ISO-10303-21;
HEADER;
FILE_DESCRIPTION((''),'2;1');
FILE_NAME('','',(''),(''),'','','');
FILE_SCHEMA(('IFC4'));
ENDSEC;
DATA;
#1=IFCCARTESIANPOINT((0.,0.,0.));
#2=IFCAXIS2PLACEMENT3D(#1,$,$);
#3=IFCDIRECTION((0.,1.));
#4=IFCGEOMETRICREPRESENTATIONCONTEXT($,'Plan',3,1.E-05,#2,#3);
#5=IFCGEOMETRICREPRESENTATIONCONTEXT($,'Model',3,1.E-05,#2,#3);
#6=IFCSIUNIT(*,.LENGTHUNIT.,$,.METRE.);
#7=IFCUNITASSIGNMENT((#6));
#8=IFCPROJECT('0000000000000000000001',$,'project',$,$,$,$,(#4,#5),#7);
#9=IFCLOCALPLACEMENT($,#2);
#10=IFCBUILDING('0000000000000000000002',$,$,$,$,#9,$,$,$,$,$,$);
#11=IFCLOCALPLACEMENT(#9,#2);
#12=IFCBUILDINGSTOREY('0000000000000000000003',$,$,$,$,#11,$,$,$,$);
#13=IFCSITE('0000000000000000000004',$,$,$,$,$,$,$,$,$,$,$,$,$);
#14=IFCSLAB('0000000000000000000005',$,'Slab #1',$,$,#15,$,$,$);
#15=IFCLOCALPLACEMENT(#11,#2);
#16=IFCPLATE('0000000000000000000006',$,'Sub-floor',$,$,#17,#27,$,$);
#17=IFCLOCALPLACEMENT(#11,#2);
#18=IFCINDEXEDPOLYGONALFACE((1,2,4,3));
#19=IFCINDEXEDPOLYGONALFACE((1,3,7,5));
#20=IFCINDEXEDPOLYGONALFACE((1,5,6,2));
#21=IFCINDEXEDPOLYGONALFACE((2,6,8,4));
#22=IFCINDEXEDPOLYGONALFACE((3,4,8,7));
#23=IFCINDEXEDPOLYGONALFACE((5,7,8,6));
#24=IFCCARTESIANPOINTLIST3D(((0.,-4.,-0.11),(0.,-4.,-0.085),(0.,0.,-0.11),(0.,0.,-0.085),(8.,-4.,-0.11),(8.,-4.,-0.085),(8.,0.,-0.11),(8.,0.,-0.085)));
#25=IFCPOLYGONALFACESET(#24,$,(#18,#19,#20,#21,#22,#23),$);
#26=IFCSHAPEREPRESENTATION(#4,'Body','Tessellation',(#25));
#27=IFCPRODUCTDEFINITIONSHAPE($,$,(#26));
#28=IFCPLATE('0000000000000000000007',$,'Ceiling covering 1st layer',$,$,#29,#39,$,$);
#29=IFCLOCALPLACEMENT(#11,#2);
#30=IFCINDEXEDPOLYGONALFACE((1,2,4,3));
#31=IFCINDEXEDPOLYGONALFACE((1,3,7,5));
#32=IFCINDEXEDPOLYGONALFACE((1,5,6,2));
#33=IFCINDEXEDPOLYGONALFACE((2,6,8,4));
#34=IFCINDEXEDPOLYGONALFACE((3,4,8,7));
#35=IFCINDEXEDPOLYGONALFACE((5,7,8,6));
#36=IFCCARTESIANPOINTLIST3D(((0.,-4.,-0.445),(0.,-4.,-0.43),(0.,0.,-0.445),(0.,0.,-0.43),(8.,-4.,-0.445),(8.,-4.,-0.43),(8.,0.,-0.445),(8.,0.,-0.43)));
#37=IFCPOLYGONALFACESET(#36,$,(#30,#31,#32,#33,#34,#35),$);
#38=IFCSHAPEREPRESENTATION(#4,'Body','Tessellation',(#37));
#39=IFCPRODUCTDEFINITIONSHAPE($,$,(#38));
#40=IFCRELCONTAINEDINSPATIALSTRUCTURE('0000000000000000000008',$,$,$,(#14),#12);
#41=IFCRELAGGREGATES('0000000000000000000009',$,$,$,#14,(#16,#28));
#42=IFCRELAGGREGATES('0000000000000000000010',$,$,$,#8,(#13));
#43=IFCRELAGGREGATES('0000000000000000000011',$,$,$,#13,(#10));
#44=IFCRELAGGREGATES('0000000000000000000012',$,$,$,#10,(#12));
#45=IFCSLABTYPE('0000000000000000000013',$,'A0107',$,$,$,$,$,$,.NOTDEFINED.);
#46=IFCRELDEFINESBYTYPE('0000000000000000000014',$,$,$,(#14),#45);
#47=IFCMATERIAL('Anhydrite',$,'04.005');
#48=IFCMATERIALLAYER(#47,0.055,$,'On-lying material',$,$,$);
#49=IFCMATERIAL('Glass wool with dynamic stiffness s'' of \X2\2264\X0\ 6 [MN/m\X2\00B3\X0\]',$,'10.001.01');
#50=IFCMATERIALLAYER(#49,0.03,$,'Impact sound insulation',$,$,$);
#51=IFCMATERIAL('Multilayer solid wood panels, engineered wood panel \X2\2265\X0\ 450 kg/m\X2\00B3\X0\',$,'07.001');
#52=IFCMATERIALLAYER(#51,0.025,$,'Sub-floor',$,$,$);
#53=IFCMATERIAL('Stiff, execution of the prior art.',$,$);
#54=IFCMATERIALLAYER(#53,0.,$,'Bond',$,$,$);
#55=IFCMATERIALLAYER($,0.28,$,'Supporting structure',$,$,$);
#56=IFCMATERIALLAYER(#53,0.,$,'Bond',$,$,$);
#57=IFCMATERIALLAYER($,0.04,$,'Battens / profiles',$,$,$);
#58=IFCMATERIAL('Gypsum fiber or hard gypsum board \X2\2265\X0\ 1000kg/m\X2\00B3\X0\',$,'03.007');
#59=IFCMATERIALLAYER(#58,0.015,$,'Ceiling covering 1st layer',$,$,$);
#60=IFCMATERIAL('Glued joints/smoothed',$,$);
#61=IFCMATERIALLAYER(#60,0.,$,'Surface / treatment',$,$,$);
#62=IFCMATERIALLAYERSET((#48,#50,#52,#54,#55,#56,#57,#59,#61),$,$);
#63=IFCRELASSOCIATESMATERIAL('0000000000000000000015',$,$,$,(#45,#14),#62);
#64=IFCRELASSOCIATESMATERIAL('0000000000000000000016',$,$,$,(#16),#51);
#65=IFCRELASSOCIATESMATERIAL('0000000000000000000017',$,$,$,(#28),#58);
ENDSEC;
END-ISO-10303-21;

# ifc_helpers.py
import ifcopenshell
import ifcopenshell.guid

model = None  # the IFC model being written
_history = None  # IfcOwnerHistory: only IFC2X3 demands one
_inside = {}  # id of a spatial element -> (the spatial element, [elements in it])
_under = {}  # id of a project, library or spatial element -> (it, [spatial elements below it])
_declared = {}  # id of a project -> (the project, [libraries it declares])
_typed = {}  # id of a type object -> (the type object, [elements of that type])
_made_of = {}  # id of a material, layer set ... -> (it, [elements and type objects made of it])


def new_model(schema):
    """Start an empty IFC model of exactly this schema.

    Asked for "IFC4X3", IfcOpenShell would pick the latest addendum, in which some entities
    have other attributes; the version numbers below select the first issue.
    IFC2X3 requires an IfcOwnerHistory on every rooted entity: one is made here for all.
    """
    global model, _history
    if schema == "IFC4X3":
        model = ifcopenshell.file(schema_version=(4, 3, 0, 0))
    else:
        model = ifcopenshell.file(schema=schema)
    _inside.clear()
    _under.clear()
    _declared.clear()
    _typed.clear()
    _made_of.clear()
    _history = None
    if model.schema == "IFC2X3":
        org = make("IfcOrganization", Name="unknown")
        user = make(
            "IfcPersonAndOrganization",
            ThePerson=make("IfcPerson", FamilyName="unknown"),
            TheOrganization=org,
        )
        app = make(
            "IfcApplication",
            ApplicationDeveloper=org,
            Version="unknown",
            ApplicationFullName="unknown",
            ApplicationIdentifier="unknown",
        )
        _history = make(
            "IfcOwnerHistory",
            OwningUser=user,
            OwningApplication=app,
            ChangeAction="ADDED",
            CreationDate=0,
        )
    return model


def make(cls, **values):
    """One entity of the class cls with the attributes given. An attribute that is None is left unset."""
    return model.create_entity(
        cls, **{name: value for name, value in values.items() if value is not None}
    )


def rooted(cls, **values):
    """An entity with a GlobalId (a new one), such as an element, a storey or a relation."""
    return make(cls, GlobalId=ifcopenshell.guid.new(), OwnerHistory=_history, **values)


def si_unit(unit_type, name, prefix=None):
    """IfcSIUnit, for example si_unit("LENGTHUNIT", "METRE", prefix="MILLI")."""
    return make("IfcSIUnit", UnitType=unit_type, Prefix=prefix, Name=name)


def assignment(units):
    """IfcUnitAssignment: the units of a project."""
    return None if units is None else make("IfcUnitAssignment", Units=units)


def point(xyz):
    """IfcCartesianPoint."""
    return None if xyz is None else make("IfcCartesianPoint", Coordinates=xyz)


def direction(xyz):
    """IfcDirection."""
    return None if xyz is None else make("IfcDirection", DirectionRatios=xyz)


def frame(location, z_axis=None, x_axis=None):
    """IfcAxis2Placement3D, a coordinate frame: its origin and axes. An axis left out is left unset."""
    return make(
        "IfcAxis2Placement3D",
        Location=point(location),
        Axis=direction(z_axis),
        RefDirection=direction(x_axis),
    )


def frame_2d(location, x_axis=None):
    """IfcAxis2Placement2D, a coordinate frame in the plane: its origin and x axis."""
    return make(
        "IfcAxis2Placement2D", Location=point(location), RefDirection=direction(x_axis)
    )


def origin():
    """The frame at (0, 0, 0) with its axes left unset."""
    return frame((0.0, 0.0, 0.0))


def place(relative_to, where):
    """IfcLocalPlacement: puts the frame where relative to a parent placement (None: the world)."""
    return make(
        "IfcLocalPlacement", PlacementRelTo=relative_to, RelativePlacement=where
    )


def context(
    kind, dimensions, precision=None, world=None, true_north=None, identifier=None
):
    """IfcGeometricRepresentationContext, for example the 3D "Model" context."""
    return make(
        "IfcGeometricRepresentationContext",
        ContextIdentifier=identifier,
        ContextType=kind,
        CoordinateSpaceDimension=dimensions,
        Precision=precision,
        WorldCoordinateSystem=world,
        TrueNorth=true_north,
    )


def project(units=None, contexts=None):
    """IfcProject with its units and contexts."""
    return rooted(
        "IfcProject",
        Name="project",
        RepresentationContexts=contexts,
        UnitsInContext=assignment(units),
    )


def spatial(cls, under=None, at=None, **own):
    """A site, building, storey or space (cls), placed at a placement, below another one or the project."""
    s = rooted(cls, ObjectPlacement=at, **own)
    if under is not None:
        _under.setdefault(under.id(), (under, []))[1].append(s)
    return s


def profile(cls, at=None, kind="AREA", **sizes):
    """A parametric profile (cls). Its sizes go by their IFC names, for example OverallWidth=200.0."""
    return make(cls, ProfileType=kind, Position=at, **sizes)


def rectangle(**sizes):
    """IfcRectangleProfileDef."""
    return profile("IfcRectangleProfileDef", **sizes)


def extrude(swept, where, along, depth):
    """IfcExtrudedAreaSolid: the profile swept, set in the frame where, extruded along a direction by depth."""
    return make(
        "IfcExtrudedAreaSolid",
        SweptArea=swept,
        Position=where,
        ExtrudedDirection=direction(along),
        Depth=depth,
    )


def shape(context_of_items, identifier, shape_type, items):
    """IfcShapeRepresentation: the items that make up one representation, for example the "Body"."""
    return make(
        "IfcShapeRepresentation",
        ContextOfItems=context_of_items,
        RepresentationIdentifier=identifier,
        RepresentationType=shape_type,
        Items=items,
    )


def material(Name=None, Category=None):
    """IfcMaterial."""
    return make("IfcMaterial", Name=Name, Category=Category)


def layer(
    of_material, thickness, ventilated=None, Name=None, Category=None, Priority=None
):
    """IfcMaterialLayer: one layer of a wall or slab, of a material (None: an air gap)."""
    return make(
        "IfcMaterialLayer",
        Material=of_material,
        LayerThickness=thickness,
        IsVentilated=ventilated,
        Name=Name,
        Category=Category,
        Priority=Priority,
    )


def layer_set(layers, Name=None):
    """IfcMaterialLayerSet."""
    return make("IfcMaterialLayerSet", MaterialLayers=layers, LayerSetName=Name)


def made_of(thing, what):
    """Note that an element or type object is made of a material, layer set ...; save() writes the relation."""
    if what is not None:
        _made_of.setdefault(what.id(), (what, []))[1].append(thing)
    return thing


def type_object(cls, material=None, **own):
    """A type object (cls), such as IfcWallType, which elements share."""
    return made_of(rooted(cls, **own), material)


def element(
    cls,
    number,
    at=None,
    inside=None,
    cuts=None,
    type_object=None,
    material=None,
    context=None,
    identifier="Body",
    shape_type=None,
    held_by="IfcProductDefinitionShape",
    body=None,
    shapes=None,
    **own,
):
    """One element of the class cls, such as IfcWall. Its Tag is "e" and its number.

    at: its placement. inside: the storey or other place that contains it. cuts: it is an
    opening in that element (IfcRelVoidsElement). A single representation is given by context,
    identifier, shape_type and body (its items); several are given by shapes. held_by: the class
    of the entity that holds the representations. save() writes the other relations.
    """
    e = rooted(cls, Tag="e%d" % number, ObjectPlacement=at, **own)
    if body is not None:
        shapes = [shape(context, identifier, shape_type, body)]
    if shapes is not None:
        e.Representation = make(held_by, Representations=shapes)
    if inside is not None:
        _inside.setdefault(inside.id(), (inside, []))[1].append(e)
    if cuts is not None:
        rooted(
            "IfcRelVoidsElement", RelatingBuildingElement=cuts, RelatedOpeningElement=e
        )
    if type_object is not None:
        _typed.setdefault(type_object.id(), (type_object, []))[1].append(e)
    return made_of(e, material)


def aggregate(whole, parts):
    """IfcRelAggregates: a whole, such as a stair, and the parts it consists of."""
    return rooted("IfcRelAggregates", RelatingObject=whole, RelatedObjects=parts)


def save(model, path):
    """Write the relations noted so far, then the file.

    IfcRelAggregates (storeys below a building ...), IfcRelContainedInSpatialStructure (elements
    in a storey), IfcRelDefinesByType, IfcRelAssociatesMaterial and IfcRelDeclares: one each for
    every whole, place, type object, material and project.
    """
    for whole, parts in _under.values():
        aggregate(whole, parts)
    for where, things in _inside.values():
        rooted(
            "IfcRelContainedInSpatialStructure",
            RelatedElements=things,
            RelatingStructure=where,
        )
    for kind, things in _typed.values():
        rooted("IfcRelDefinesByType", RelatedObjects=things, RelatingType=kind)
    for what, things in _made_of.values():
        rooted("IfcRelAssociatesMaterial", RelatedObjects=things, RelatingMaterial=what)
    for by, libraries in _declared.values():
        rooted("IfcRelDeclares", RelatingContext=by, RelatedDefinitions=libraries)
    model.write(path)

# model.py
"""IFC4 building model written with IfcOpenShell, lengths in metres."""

from ifc_helpers import new_model, si_unit, direction, frame, frame_2d, origin, place, context, project, spatial, rectangle, extrude, material, layer, layer_set, type_object, element, aggregate, save


model = new_model("IFC4")

# Units and contexts
plan_context = context("Plan", 3, precision=1e-05, world=origin(), true_north=direction((0.0, 1.0)))
model_context = context("Model", 3, precision=1e-05, world=origin(), true_north=direction((0.0, 1.0)))
ifc_project = project(units=[si_unit("LENGTHUNIT", "METRE")], contexts=[plan_context, model_context])

# Site, building, storey
site = spatial("IfcSite", under=ifc_project)
building_placement = place(None, origin())
building = spatial("IfcBuilding", under=site, at=building_placement)
storey_placement = place(building_placement, origin())
storey = spatial("IfcBuildingStorey", under=building, at=storey_placement)

# Slab, plates
ifc_material_1 = material(Name="Anhydrite", Category="04.005")
ifc_layer_1 = layer(ifc_material_1, 0.055, Name="On-lying material")
ifc_material_2 = material(Name="Glass wool with dynamic stiffness s' of ≤ 6 [MN/m³]", Category="10.001.01")
ifc_layer_2 = layer(ifc_material_2, 0.03, Name="Impact sound insulation")
ifc_material_3 = material(Name="Multilayer solid wood panels, engineered wood panel ≥ 450 kg/m³", Category="07.001")
ifc_layer_3 = layer(ifc_material_3, 0.025, Name="Sub-floor")
ifc_material_4 = material(Name="Stiff, execution of the prior art.")
ifc_layer_4 = layer(ifc_material_4, 0.0, Name="Bond")
ifc_layer_5 = layer(None, 0.28, Name="Supporting structure")
ifc_layer_6 = layer(ifc_material_4, 0.0, Name="Bond")
ifc_layer_7 = layer(None, 0.04, Name="Battens / profiles")
ifc_material_5 = material(Name="Gypsum fiber or hard gypsum board ≥ 1000kg/m³", Category="03.007")
ifc_layer_8 = layer(ifc_material_5, 0.015, Name="Ceiling covering 1st layer")
ifc_material_6 = material(Name="Glued joints/smoothed")
ifc_layer_9 = layer(ifc_material_6, 0.0, Name="Surface / treatment")
ifc_layer_set = layer_set([ifc_layer_1, ifc_layer_2, ifc_layer_3, ifc_layer_4, ifc_layer_5, ifc_layer_6, ifc_layer_7, ifc_layer_8, ifc_layer_9])
slab_type = type_object("IfcSlabType", Name="A0107", PredefinedType="NOTDEFINED", material=ifc_layer_set)
slab_placement = place(None, frame((0.0, 0.0, 0.0), z_axis=(0.0, 0.0, -1.0), x_axis=(1.0, 0.0, 0.0)))
slab = element("IfcSlab", 1, at=slab_placement, inside=storey, type_object=slab_type, material=ifc_layer_set, Name="Slab #1")
plate_1_placement = place(slab_placement, origin())
plate_1 = element("IfcPlate", 2, at=plate_1_placement, material=ifc_material_3, Name="Sub-floor", context=plan_context, shape_type="SweptSolid", body=[
    extrude(rectangle(XDim=8.0, YDim=4.0, at=frame_2d((4.0, 2.0), x_axis=(1.0, 0.0))), frame((0.0, 0.0, 0.085), z_axis=(0.0, 0.0, 1.0), x_axis=(1.0, 0.0, 0.0)), (0.0, 0.0, 1.0), 0.025),
])
plate_2_placement = place(slab_placement, origin())
plate_2 = element("IfcPlate", 3, at=plate_2_placement, material=ifc_material_5, Name="Ceiling covering 1st layer", context=plan_context, shape_type="SweptSolid", body=[
    extrude(rectangle(XDim=8.0, YDim=4.0, at=frame_2d((4.0, 2.0), x_axis=(1.0, 0.0))), frame((0.0, 0.0, 0.43), z_axis=(0.0, 0.0, 1.0), x_axis=(1.0, 0.0, 0.0)), (0.0, 0.0, 1.0), 0.015),
])
aggregate(slab, [plate_1, plate_2])

save(model, "model.ifc")
